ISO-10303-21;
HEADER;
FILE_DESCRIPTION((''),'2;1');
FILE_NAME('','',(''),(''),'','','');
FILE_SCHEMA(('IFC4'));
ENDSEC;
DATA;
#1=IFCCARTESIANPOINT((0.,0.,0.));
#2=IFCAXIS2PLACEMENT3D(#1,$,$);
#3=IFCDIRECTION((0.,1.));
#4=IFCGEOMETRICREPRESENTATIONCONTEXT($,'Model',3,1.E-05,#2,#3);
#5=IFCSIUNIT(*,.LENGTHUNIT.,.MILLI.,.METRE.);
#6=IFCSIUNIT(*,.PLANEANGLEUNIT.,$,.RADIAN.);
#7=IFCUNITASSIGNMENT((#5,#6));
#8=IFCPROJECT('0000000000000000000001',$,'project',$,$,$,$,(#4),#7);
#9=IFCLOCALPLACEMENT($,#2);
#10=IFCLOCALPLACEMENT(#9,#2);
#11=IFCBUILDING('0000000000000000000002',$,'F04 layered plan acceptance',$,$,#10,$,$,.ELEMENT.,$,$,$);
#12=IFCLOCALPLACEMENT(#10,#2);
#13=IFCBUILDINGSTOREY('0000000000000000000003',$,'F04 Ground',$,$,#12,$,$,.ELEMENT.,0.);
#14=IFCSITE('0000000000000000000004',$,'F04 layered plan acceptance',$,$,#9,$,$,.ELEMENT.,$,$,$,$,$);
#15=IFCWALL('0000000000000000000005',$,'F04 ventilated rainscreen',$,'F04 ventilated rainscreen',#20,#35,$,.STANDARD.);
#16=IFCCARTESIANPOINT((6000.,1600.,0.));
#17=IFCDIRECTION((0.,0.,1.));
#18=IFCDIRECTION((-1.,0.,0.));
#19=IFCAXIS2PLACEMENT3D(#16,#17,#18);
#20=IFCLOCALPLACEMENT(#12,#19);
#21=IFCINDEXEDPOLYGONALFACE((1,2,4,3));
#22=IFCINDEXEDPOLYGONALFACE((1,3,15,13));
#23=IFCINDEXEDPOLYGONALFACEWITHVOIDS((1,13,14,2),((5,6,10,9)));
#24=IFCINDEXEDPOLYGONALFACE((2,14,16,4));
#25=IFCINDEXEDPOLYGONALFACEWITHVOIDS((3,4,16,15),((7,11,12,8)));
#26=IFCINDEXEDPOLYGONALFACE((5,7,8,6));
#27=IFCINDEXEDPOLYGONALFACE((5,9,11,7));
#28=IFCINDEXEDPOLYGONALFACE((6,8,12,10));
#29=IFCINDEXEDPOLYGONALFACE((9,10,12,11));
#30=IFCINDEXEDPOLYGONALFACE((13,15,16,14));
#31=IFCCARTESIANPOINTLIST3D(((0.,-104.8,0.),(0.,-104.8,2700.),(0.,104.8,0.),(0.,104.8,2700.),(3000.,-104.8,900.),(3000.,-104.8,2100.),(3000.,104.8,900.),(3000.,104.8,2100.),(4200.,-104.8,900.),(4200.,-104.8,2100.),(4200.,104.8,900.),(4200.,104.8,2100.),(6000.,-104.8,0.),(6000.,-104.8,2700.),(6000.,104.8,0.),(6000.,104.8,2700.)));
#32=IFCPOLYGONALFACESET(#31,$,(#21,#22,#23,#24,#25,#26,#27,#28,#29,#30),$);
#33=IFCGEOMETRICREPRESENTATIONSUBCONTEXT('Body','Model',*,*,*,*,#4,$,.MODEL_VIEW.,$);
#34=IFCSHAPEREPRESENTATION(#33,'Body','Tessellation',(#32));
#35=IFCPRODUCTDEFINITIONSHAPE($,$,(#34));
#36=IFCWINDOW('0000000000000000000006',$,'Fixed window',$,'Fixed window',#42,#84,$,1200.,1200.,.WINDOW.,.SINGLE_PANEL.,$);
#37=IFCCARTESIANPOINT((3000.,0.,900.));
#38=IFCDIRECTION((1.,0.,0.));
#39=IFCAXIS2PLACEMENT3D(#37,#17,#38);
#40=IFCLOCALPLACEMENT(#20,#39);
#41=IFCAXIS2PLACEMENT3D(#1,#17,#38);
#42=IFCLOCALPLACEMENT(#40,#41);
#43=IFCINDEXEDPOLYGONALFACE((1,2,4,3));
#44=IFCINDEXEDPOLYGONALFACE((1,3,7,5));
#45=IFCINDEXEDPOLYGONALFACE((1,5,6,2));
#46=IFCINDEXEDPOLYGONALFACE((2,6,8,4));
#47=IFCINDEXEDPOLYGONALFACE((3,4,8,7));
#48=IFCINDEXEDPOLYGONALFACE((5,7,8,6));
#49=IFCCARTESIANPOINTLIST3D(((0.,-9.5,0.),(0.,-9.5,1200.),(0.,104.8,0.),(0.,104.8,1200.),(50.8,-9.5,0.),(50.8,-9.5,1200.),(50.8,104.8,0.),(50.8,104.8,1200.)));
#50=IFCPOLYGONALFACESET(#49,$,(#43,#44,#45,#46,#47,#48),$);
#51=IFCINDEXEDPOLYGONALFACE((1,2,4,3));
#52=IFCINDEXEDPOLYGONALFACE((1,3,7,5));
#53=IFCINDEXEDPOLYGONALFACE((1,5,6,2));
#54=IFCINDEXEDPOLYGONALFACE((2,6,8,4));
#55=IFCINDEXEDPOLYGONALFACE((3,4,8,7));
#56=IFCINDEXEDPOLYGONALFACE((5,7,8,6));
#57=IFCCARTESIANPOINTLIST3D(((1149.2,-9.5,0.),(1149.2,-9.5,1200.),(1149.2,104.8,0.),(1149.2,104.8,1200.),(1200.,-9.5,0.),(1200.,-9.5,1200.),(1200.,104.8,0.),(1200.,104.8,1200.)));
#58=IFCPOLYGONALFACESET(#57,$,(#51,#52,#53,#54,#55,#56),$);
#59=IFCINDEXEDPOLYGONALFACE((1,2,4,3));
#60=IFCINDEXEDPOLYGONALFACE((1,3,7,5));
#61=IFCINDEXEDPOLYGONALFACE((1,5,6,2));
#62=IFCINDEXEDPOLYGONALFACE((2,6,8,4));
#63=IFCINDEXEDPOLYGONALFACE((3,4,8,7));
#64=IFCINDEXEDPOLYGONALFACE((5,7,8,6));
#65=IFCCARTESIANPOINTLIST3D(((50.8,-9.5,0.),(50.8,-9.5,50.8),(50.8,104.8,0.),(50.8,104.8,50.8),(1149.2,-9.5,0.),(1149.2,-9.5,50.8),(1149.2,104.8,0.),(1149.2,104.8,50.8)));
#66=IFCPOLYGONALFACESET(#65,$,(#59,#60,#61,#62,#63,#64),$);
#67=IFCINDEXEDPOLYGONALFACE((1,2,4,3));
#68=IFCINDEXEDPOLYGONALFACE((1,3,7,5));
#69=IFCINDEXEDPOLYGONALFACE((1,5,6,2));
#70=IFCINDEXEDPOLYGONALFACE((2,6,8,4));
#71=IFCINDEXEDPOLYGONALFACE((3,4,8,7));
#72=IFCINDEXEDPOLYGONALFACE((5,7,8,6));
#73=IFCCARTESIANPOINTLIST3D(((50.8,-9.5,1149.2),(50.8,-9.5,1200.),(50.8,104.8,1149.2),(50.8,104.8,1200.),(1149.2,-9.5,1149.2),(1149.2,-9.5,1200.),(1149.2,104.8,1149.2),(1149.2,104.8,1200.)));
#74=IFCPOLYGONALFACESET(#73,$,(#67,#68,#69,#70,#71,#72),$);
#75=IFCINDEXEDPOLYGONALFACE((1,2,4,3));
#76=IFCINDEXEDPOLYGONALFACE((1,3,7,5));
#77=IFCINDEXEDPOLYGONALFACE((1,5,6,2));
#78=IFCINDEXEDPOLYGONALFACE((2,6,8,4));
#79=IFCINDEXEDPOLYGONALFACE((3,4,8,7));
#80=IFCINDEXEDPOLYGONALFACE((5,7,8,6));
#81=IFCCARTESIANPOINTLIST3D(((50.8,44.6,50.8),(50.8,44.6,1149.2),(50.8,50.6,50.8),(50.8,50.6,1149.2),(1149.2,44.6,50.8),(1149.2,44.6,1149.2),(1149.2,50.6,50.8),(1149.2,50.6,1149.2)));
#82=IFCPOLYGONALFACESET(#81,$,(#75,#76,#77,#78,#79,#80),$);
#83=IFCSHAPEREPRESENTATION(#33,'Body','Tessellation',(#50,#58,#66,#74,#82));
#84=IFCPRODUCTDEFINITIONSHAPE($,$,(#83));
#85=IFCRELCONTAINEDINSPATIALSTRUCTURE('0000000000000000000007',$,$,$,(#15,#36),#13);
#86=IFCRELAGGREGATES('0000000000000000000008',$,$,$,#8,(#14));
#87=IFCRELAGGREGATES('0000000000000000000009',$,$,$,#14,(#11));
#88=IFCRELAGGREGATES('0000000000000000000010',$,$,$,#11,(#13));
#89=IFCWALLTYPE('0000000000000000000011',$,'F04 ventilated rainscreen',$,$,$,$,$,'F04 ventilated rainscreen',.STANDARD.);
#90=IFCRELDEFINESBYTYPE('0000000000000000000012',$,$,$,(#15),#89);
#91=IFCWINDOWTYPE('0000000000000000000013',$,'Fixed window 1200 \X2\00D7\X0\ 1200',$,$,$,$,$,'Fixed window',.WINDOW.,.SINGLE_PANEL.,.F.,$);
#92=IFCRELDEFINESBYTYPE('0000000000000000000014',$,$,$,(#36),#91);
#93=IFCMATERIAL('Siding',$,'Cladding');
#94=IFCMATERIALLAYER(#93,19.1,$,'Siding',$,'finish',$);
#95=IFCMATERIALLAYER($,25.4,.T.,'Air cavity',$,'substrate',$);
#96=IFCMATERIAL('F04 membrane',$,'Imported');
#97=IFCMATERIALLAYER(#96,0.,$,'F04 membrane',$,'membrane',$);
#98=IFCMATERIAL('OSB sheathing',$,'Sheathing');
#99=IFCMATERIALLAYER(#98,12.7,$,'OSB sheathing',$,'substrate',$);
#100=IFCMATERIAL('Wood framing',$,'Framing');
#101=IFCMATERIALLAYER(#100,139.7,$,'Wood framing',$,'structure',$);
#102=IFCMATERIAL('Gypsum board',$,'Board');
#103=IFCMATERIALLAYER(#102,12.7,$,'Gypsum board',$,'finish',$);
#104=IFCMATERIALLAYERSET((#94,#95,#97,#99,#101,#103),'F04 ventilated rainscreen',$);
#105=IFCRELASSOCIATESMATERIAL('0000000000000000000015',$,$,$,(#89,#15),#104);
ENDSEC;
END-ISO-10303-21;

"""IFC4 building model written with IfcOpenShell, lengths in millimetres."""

from ifc_helpers import new_model, si_unit, direction, frame, origin, origin_with_axes, place, context, subcontext, project, spatial, polyline, outline, extrude, material, layer, layer_set, layer_usage, type_object, element, fill, save


model = new_model("IFC4")

# Units and contexts
model_context = context("Model", 3, precision=1e-05, world=origin(), true_north=direction((0.0, 1.0)))
body_context = subcontext(model_context, "Body", "Model", "MODEL_VIEW")
ifc_project = project(units=[si_unit("LENGTHUNIT", "METRE", prefix="MILLI"), si_unit("PLANEANGLEUNIT", "RADIAN")], contexts=[model_context])

# Site, building, storey
site_placement = place(None, origin())
site = spatial("IfcSite", under=ifc_project, at=site_placement, Name="F04 layered plan acceptance", CompositionType="ELEMENT")
building_placement = place(site_placement, origin())
building = spatial("IfcBuilding", under=site, at=building_placement, Name="F04 layered plan acceptance", CompositionType="ELEMENT")
storey_placement = place(building_placement, origin())
storey = spatial("IfcBuildingStorey", under=building, at=storey_placement, Name="F04 Ground", CompositionType="ELEMENT", Elevation=0.0)

# Shared definitions
ifc_material_1 = material(Name="Siding", Category="Cladding")
ifc_layer_1 = layer(ifc_material_1, 19.1, Name="Siding", Category="finish")
ifc_layer_2 = layer(None, 25.4, ventilated=True, Name="Air cavity", Category="substrate")
ifc_material_2 = material(Name="F04 membrane", Category="Imported")
ifc_layer_3 = layer(ifc_material_2, 0.0, Name="F04 membrane", Category="membrane")
ifc_material_3 = material(Name="OSB sheathing", Category="Sheathing")
ifc_layer_4 = layer(ifc_material_3, 12.7, Name="OSB sheathing", Category="substrate")
ifc_material_4 = material(Name="Wood framing", Category="Framing")
ifc_layer_5 = layer(ifc_material_4, 139.7, Name="Wood framing", Category="structure")
ifc_material_5 = material(Name="Gypsum board", Category="Board")
ifc_layer_6 = layer(ifc_material_5, 12.7, Name="Gypsum board", Category="finish")
ifc_layer_set_1 = layer_set([ifc_layer_1, ifc_layer_2, ifc_layer_3, ifc_layer_4, ifc_layer_5, ifc_layer_6], Name="F04 ventilated rainscreen")
wall_type_1 = type_object("IfcWallType", Name="F04 ventilated rainscreen", ElementType="F04 ventilated rainscreen", PredefinedType="STANDARD", material=ifc_layer_set_1)

# Wall, opening, window
ifc_layer_usage_1 = layer_usage(ifc_layer_set_1, "AXIS2", "POSITIVE", -104.8)
wall_1_placement = place(storey_placement, frame((6000.0, 1600.0, 0.0), z_axis=(0.0, 0.0, 1.0), x_axis=(-1.0, 0.0, 0.0)))
wall_1 = element("IfcWall", 1, at=wall_1_placement, inside=storey, type_object=wall_type_1, material=ifc_layer_usage_1, Name="F04 ventilated rainscreen", ObjectType="F04 ventilated rainscreen", PredefinedType="STANDARD", context=body_context, shape_type="SweptSolid", body=[
    extrude(outline(polyline([(0.0, -104.8), (6000.0, -104.8), (6000.0, 104.8), (0.0, 104.8), (0.0, -104.8)])), origin(), (0.0, 0.0, 1.0), 2700.0),
])
opening_1_placement = place(wall_1_placement, frame((3000.0, 0.0, 900.0), z_axis=(0.0, 0.0, 1.0), x_axis=(1.0, 0.0, 0.0)))
opening_1 = element("IfcOpeningElement", 2, at=opening_1_placement, cuts=wall_1, PredefinedType="OPENING", context=body_context, shape_type="SweptSolid", body=[
    extrude(outline(polyline([(0.0, -114.8), (1200.0, -114.8), (1200.0, 114.8), (0.0, 114.8), (0.0, -114.8)])), origin(), (0.0, 0.0, 1.0), 1200.0),
])
window_type_1 = type_object("IfcWindowType", Name="Fixed window 1200 × 1200", ElementType="Fixed window", ParameterTakesPrecedence=False, PartitioningType="SINGLE_PANEL", PredefinedType="WINDOW")
window_1_placement = place(opening_1_placement, origin_with_axes())
window_1 = element("IfcWindow", 3, at=window_1_placement, inside=storey, type_object=window_type_1, Name="Fixed window", ObjectType="Fixed window", OverallHeight=1200.0, OverallWidth=1200.0, PartitioningType="SINGLE_PANEL", PredefinedType="WINDOW", context=body_context, shape_type="SweptSolid", body=[
    extrude(outline(polyline([(0.0, -9.5), (50.8, -9.5), (50.8, 104.8), (0.0, 104.8), (0.0, -9.5)])), origin(), (0.0, 0.0, 1.0), 1200.0),
    extrude(outline(polyline([(1149.2, -9.5), (1200.0, -9.5), (1200.0, 104.8), (1149.2, 104.8), (1149.2, -9.5)])), origin(), (0.0, 0.0, 1.0), 1200.0),
    extrude(outline(polyline([(50.8, -9.5), (1149.2, -9.5), (1149.2, 104.8), (50.8, 104.8), (50.8, -9.5)])), origin(), (0.0, 0.0, 1.0), 50.8),
    extrude(outline(polyline([(50.8, -9.5), (1149.2, -9.5), (1149.2, 104.8), (50.8, 104.8), (50.8, -9.5)])), frame((0.0, 0.0, 1149.2)), (0.0, 0.0, 1.0), 50.8),
    extrude(outline(polyline([(50.8, 44.6), (1149.2, 44.6), (1149.2, 50.6), (50.8, 50.6), (50.8, 44.6)])), frame((0.0, 0.0, 50.8)), (0.0, 0.0, 1.0), 1098.4),
])
fill(opening_1, window_1)

save(model, "model.ifc")
